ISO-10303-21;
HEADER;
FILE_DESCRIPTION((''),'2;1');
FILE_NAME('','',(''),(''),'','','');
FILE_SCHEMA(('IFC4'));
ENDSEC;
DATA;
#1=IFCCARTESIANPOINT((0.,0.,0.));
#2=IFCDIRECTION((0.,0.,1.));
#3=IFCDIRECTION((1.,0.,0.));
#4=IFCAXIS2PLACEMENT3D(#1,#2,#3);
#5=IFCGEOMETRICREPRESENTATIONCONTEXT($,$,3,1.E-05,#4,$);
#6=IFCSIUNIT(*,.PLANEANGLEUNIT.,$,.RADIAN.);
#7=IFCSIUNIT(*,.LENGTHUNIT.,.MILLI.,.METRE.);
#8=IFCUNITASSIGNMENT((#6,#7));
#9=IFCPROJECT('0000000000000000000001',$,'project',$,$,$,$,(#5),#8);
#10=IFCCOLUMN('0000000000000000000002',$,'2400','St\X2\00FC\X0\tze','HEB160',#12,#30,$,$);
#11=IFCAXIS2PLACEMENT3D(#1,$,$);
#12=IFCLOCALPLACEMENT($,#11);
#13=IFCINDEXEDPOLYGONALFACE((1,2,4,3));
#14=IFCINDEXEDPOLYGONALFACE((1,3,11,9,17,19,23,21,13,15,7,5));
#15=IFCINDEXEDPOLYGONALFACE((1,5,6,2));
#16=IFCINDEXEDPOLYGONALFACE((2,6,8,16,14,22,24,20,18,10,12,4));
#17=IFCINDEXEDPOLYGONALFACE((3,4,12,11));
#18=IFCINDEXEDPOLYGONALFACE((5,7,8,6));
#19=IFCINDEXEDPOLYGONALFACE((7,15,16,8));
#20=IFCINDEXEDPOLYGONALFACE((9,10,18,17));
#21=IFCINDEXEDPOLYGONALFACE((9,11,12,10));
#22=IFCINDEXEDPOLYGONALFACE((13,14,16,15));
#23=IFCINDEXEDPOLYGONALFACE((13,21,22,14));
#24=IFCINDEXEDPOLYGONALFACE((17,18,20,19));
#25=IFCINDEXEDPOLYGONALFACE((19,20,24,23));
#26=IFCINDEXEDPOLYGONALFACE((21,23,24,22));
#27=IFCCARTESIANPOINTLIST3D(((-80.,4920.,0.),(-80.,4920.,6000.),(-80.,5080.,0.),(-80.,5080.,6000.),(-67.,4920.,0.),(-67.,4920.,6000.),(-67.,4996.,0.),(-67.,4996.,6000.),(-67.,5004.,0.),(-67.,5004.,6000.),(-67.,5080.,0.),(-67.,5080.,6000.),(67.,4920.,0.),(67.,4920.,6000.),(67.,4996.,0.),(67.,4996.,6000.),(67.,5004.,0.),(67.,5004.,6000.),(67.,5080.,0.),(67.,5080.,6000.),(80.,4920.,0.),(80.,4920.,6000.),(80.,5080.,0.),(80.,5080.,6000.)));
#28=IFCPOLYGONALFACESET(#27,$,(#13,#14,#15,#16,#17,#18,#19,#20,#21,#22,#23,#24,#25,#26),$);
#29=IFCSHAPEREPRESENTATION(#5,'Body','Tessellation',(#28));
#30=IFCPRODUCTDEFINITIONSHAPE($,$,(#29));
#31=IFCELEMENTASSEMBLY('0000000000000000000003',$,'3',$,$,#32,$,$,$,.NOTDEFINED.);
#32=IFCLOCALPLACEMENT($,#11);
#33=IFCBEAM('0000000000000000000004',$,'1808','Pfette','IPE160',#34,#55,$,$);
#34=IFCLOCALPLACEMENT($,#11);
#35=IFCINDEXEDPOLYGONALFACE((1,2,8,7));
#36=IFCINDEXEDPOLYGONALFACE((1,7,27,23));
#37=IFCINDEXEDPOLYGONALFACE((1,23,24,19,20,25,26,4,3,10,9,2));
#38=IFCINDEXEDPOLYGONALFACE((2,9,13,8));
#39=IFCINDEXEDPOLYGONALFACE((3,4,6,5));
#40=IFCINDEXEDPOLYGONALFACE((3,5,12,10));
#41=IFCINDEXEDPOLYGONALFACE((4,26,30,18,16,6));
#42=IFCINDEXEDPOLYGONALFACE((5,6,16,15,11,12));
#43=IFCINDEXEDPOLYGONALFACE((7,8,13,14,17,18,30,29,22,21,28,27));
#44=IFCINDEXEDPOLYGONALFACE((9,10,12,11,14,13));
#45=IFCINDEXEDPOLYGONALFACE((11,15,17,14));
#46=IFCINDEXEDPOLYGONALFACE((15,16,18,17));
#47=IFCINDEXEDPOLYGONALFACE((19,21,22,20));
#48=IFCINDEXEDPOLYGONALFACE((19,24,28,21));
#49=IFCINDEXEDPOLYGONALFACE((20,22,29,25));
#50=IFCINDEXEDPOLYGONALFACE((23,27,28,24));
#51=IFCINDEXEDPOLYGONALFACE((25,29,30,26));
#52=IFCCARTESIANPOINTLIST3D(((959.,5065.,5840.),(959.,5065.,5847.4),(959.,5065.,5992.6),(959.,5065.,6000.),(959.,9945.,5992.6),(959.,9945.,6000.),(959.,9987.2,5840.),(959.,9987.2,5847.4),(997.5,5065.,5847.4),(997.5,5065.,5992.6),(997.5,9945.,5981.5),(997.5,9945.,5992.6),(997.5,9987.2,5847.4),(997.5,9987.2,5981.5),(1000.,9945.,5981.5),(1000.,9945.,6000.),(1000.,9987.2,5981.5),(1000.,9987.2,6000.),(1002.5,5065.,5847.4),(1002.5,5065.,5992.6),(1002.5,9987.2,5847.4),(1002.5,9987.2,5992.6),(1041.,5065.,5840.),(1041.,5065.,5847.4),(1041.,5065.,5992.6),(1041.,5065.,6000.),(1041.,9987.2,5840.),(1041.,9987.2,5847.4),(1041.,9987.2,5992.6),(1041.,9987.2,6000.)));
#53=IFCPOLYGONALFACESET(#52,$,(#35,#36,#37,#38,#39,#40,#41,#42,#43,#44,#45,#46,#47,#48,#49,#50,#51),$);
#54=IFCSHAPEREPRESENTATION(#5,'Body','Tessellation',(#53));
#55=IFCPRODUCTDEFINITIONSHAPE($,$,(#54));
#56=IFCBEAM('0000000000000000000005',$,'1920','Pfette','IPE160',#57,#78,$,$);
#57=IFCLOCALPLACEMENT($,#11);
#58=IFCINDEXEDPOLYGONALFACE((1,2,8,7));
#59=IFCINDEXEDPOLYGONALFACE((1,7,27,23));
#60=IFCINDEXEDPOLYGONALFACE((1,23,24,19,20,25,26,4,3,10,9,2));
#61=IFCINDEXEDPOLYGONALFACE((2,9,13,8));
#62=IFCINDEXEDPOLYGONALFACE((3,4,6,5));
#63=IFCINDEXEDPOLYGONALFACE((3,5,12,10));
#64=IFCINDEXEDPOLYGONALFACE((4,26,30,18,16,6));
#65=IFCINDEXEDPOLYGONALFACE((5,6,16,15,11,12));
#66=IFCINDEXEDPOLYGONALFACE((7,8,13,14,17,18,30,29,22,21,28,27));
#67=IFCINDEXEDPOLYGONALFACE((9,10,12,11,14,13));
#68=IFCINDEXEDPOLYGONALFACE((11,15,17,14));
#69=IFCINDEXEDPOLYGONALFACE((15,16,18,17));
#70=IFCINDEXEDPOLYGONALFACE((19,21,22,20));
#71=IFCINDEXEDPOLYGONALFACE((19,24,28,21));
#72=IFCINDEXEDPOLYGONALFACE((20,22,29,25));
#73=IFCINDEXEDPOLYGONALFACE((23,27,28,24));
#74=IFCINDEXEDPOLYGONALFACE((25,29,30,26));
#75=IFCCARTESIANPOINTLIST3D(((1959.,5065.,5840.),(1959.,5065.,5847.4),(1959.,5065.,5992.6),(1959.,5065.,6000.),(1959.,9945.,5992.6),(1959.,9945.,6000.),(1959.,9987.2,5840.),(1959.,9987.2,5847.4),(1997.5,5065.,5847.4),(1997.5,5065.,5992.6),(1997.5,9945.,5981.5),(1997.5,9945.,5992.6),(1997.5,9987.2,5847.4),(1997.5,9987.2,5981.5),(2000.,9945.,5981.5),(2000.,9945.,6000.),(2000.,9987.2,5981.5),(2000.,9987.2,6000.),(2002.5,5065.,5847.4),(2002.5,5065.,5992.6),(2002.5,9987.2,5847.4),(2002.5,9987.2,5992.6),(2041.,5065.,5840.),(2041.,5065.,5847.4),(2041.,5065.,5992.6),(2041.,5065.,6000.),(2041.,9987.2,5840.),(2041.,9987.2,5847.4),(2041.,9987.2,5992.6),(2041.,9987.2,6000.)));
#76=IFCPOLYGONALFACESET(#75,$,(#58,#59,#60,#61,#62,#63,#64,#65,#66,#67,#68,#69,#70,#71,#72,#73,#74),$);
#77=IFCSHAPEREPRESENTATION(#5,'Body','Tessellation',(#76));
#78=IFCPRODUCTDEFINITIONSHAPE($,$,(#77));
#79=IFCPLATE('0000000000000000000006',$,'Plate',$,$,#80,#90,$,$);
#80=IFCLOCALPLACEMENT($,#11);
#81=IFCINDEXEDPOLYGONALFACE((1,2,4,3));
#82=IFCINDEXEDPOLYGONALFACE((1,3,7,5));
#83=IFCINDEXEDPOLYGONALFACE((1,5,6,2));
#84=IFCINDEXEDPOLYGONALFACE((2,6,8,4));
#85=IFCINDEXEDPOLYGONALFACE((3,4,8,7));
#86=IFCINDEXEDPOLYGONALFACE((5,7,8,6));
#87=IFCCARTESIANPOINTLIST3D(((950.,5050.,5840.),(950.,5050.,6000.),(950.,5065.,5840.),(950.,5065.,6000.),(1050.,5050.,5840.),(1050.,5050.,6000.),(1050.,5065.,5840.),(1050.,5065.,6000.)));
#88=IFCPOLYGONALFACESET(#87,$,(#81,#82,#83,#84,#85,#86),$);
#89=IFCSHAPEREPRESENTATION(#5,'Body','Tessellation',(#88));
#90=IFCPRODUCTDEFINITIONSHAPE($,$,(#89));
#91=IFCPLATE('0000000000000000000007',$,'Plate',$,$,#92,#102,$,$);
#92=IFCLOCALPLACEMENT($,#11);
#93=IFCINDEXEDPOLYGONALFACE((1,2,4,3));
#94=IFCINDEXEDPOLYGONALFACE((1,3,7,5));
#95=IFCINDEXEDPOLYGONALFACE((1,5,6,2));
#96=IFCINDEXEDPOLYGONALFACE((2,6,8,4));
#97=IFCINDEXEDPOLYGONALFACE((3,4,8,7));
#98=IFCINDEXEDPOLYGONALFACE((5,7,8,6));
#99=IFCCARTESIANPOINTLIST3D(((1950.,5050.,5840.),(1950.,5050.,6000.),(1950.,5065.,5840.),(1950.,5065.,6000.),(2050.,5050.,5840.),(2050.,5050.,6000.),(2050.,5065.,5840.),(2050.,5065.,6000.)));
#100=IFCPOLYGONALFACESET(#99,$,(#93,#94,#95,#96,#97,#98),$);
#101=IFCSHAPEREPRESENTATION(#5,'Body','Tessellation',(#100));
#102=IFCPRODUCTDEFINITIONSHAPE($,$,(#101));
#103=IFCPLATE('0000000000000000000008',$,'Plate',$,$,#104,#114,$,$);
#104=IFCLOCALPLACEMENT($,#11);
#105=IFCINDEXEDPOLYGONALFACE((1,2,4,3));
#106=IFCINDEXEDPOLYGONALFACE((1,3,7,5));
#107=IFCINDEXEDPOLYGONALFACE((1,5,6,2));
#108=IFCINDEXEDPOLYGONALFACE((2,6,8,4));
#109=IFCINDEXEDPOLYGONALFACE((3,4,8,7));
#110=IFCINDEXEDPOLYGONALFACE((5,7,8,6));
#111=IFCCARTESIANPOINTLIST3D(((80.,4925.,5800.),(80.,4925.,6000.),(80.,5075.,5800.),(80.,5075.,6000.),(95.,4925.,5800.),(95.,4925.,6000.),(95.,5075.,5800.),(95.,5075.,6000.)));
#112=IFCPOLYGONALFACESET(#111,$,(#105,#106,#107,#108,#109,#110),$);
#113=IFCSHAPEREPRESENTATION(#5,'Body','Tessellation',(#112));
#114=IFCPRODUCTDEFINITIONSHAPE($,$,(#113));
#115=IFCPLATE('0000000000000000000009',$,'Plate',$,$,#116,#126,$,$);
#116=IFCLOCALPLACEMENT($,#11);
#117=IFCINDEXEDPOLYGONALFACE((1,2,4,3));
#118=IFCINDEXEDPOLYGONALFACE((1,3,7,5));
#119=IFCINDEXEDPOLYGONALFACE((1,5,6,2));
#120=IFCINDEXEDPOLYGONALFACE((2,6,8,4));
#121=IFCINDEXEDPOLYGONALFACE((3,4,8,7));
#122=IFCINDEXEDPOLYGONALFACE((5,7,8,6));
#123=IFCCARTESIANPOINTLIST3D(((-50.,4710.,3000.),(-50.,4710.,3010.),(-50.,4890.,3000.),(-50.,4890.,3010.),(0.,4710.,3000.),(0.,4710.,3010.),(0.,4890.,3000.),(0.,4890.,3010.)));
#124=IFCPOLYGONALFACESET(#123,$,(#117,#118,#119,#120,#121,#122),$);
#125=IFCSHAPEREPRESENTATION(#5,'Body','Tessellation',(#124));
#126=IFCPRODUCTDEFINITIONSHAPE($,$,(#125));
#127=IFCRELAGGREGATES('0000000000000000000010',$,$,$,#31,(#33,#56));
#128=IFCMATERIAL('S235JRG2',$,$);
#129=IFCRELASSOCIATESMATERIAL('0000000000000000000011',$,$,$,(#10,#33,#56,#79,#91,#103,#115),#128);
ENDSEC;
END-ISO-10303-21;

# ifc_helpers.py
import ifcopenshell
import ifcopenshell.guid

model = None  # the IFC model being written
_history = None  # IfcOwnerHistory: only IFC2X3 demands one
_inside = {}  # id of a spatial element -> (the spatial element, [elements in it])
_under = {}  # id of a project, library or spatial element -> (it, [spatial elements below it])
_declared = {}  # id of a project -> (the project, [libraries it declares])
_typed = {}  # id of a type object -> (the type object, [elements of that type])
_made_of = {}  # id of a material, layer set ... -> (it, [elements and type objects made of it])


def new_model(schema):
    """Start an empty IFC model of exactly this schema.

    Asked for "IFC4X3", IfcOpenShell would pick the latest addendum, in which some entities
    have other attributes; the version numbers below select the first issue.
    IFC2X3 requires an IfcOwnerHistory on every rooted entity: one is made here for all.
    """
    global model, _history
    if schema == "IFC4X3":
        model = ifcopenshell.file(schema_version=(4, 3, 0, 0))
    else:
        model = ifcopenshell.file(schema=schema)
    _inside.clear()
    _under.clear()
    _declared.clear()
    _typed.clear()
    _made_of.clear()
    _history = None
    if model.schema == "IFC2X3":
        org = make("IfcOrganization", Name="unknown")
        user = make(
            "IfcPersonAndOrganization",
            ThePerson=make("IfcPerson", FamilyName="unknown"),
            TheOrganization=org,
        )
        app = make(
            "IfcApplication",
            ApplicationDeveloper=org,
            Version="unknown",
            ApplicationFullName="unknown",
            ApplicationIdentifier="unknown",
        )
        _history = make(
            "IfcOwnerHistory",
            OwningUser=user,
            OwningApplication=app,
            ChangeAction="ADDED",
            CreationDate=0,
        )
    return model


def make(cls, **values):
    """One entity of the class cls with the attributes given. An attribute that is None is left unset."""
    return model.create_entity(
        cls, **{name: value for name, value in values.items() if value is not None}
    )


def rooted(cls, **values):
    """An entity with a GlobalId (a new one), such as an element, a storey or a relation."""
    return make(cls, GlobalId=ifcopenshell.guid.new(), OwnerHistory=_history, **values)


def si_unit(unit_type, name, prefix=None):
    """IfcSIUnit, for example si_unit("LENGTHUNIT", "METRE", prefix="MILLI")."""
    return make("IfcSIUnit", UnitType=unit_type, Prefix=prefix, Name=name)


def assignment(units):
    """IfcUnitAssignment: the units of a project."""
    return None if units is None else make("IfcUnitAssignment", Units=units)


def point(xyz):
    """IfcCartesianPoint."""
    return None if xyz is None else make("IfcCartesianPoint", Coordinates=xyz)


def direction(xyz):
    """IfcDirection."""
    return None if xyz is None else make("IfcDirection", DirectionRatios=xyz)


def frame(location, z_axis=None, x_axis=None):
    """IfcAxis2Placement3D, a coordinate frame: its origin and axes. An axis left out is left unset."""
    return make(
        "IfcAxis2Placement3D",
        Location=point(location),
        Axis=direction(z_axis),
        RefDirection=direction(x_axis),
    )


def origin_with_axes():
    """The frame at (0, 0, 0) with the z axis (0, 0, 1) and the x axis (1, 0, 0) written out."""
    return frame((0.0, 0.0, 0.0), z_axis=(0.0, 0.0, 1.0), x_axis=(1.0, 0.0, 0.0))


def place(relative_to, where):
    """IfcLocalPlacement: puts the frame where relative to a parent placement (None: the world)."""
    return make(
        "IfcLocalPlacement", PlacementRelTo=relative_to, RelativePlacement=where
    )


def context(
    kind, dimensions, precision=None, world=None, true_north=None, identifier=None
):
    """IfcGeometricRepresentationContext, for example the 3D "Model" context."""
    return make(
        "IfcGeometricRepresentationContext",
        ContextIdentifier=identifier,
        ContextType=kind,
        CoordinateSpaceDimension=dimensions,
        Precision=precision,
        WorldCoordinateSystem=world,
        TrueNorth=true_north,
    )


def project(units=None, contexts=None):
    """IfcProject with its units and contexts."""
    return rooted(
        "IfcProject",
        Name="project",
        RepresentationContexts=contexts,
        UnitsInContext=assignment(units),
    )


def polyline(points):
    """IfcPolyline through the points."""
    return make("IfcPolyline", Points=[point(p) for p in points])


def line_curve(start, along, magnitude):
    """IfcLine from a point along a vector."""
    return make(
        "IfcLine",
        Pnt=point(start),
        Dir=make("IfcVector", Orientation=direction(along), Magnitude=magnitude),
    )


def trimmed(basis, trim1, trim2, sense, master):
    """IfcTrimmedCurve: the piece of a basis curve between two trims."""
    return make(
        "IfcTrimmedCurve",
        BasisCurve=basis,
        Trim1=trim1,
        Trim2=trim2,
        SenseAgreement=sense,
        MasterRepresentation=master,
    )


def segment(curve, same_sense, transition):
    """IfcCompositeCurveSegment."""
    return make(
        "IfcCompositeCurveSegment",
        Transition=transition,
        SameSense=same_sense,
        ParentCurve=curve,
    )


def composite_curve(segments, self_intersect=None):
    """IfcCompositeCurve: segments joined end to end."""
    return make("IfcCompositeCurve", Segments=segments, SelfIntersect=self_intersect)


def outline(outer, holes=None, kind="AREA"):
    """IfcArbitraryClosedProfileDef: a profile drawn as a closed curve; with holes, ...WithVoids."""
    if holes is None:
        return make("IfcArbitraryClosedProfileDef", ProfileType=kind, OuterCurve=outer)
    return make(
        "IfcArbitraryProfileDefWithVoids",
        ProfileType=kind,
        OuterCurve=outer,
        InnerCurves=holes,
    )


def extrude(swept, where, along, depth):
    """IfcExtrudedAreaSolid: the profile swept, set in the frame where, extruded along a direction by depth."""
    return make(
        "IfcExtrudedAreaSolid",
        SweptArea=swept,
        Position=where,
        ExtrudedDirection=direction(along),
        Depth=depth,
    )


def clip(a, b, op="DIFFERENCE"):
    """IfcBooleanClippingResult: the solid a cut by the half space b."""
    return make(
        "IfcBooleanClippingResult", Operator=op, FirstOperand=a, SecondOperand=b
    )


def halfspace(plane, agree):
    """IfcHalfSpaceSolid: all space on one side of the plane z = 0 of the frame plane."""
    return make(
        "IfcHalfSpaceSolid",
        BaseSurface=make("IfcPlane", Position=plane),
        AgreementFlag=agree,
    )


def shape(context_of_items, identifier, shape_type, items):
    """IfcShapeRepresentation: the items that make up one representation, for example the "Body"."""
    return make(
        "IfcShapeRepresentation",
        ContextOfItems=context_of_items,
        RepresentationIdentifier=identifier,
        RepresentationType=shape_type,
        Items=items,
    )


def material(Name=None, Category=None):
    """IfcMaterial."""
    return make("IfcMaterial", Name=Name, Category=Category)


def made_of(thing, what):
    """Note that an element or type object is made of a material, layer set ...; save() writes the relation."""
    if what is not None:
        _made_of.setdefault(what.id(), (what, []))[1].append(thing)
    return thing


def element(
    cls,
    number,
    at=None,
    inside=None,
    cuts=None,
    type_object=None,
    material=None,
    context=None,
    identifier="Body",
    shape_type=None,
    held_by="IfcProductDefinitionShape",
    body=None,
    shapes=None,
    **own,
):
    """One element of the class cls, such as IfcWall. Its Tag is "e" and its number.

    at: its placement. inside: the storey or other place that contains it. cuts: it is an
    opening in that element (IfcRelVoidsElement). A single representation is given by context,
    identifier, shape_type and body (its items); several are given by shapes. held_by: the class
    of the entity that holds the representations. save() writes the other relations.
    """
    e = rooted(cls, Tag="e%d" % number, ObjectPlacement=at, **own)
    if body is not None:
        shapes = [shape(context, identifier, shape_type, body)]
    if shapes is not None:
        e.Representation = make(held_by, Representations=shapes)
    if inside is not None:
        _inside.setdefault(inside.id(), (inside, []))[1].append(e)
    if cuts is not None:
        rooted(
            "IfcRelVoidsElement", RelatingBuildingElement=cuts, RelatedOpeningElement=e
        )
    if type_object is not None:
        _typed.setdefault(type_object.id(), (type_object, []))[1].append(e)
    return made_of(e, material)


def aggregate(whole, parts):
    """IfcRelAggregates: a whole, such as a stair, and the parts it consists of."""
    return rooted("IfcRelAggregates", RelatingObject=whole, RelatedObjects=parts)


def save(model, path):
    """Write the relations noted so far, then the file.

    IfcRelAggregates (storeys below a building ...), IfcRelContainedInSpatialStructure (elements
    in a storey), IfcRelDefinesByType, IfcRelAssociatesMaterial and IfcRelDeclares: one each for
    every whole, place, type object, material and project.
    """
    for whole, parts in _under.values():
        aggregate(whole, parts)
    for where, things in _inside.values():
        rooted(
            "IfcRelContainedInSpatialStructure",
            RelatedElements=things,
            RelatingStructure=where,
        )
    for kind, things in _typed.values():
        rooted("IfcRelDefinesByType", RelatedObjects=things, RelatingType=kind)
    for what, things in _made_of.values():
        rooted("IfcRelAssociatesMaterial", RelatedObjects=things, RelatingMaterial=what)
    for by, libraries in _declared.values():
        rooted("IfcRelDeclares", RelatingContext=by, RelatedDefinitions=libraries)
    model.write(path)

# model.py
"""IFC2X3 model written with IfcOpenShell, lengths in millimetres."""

from ifc_helpers import new_model, si_unit, point, frame, origin_with_axes, place, context, project, polyline, line_curve, trimmed, segment, composite_curve, outline, extrude, clip, halfspace, material, element, aggregate, save


model = new_model("IFC2X3")

# Units and contexts
context_of_model = context(None, 3, precision=1e-05, world=origin_with_axes())
ifc_project = project(units=[si_unit("PLANEANGLEUNIT", "RADIAN"), si_unit("LENGTHUNIT", "METRE", prefix="MILLI")], contexts=[context_of_model])

# Column
ifc_material = material(Name="S235JRG2")
placement_1 = place(None, frame((0.0, 5000.0, 6000.0), z_axis=(-1.0, 0.0, 0.0), x_axis=(0.0, 0.0, -1.0)))
column_placement = place(placement_1, origin_with_axes())
element("IfcColumn", 1, at=column_placement, material=ifc_material, Name="2400", Description="Stütze", ObjectType="HEB160", context=context_of_model, shape_type="Clipping", body=[
    clip(extrude(outline(polyline([(80.0, -80.0), (80.0, -67.0), (4.0, -67.0), (4.0, 67.0), (80.0, 67.0), (80.0, 80.0), (-80.0, 80.0), (-80.0, 67.0), (-4.0, 67.0), (-4.0, -67.0), (-80.0, -67.0), (-80.0, -80.0), (80.0, -80.0), (80.0, -80.0)])), frame((0.0, 0.0, 0.0), z_axis=(1.0, 0.0, 0.0), x_axis=(0.0, 1.0, 0.0)), (0.0, 0.0, 1.0), 6000.0), halfspace(frame((6000.0, 0.0, 0.0), z_axis=(1.0, 0.0, 0.0), x_axis=(0.0, 0.0, 1.0)), False)),
])

# Element assembly, beams, openings
assembly_1_placement = place(None, frame((1000.0, 5002.5, 6000.0), z_axis=(0.0, 0.0, 1.0), x_axis=(0.0, 1.0, 0.0)))
assembly_1 = element("IfcElementAssembly", 2, at=assembly_1_placement, Name="3", PredefinedType="NOTDEFINED")
placement_2 = place(None, frame((1000.0, 5002.5, 5920.0), z_axis=(0.0, 0.0, 1.0), x_axis=(0.0, 1.0, 0.0)))
beam_1_placement = place(placement_2, origin_with_axes())
beam_1 = element("IfcBeam", 3, at=beam_1_placement, material=ifc_material, Name="1808", Description="Pfette", ObjectType="IPE160", context=context_of_model, shape_type="Clipping", body=[
    clip(clip(extrude(outline(polyline([(41.0, -80.0), (41.0, -72.6), (2.5, -72.6), (2.5, 72.6), (41.0, 72.6), (41.0, 80.0), (-41.0, 80.0), (-41.0, 72.6), (-2.5, 72.6), (-2.5, -72.6), (-41.0, -72.6), (-41.0, -80.0), (41.0, -80.0), (41.0, -80.0)])), frame((0.0, 0.0, 0.0), z_axis=(1.0, 0.0, 0.0), x_axis=(0.0, 1.0, 0.0)), (0.0, 0.0, 1.0), 4997.5), halfspace(frame((62.5, 0.0, 80.0), z_axis=(-1.0, 0.0, 0.0), x_axis=(0.0, 0.0, -1.0)), False)), halfspace(frame((4984.7, 0.0, 80.0), z_axis=(1.0, 0.0, 0.0), x_axis=(0.0, 0.0, 1.0)), False)),
])
opening_1_placement = place(beam_1_placement, frame((4942.5, 0.0, 61.5), z_axis=(0.0, 1.0, 0.0), x_axis=(-1.0, 0.0, 0.0)))
element("IfcOpeningElement", 4, at=opening_1_placement, cuts=beam_1, ObjectType="Recess", context=context_of_model, shape_type="SweptSolid", body=[
    extrude(outline(composite_curve([segment(trimmed(line_curve((0.0, 0.0), (0.0, 1.0, 0.0), 18.501), [point((0.0, 0.0))], [point((0.0, 18.5))], True, "CARTESIAN"), True, "CONTINUOUS"), segment(trimmed(line_curve((0.0, 18.5), (-1.0, 0.0, 0.0), 42.201), [point((0.0, 18.5))], [point((-42.2, 18.5))], True, "CARTESIAN"), True, "CONTINUOUS"), segment(trimmed(line_curve((-42.2, 18.5), (0.0, -1.0, 0.0), 18.501), [point((-42.2, 18.5))], [point((-42.2, 0.0))], True, "CARTESIAN"), True, "CONTINUOUS"), segment(trimmed(line_curve((-42.2, 0.0), (1.0, 0.0, 0.0), 42.201), [point((-42.2, 0.0))], [point((0.0, 0.0))], True, "CARTESIAN"), True, "CONTINUOUS")], self_intersect=False)), origin_with_axes(), (0.0, 0.0, 1.0), 3000.0),
])
placement_3 = place(None, frame((2000.0, 5002.5, 5920.0), z_axis=(0.0, 0.0, 1.0), x_axis=(0.0, 1.0, 0.0)))
beam_2_placement = place(placement_3, origin_with_axes())
beam_2 = element("IfcBeam", 5, at=beam_2_placement, material=ifc_material, Name="1920", Description="Pfette", ObjectType="IPE160", context=context_of_model, shape_type="Clipping", body=[
    clip(clip(extrude(outline(polyline([(41.0, -80.0), (41.0, -72.6), (2.5, -72.6), (2.5, 72.6), (41.0, 72.6), (41.0, 80.0), (-41.0, 80.0), (-41.0, 72.6), (-2.5, 72.6), (-2.5, -72.6), (-41.0, -72.6), (-41.0, -80.0), (41.0, -80.0), (41.0, -80.0)])), frame((0.0, 0.0, 0.0), z_axis=(1.0, 0.0, 0.0), x_axis=(0.0, 1.0, 0.0)), (0.0, 0.0, 1.0), 4997.5), halfspace(frame((62.5, 0.0, 80.0), z_axis=(-1.0, 0.0, 0.0), x_axis=(0.0, 0.0, -1.0)), False)), halfspace(frame((4984.7, 0.0, 80.0), z_axis=(1.0, 0.0, 0.0), x_axis=(0.0, 0.0, 1.0)), False)),
])
opening_2_placement = place(beam_2_placement, frame((4942.5, 0.0, 61.5), z_axis=(0.0, 1.0, 0.0), x_axis=(-1.0, 0.0, 0.0)))
element("IfcOpeningElement", 6, at=opening_2_placement, cuts=beam_2, ObjectType="Recess", context=context_of_model, shape_type="SweptSolid", body=[
    extrude(outline(composite_curve([segment(trimmed(line_curve((0.0, 0.0), (0.0, 1.0, 0.0), 18.501), [point((0.0, 0.0))], [point((0.0, 18.5))], True, "CARTESIAN"), True, "CONTINUOUS"), segment(trimmed(line_curve((0.0, 18.5), (-1.0, 0.0, 0.0), 42.201), [point((0.0, 18.5))], [point((-42.2, 18.5))], True, "CARTESIAN"), True, "CONTINUOUS"), segment(trimmed(line_curve((-42.2, 18.5), (0.0, -1.0, 0.0), 18.501), [point((-42.2, 18.5))], [point((-42.2, 0.0))], True, "CARTESIAN"), True, "CONTINUOUS"), segment(trimmed(line_curve((-42.2, 0.0), (1.0, 0.0, 0.0), 42.201), [point((-42.2, 0.0))], [point((0.0, 0.0))], True, "CARTESIAN"), True, "CONTINUOUS")], self_intersect=False)), origin_with_axes(), (0.0, 0.0, 1.0), 3000.0),
])
aggregate(assembly_1, [beam_1, beam_2])

# Plates
placement_4 = place(None, origin_with_axes())
plate_1_placement = place(placement_4, frame((1050.0, 5065.0, 5840.0), z_axis=(-1.0, 0.0, 0.0), x_axis=(0.0, -1.0, 0.0)))
element("IfcPlate", 7, at=plate_1_placement, material=ifc_material, Name="Plate", context=context_of_model, shape_type="SweptSolid", body=[
    extrude(outline(polyline([(0.0, 0.0), (160.0, 0.0), (160.0, 100.0), (0.0, 100.0), (0.0, 0.0)])), frame((0.0, 0.0, 0.0), z_axis=(1.0, 0.0, 0.0), x_axis=(0.0, 1.0, 0.0)), (0.0, 0.0, 1.0), 15.0),
])
placement_5 = place(None, origin_with_axes())
plate_2_placement = place(placement_5, frame((2050.0, 5065.0, 5840.0), z_axis=(-1.0, 0.0, 0.0), x_axis=(0.0, -1.0, 0.0)))
element("IfcPlate", 8, at=plate_2_placement, material=ifc_material, Name="Plate", context=context_of_model, shape_type="SweptSolid", body=[
    extrude(outline(polyline([(0.0, 0.0), (160.0, 0.0), (160.0, 100.0), (0.0, 100.0), (0.0, 0.0)])), frame((0.0, 0.0, 0.0), z_axis=(1.0, 0.0, 0.0), x_axis=(0.0, 1.0, 0.0)), (0.0, 0.0, 1.0), 15.0),
])
placement_6 = place(None, origin_with_axes())
plate_3_placement = place(placement_6, frame((95.0, 4925.0, 5800.0), z_axis=(0.0, 1.0, 0.0), x_axis=(-1.0, 0.0, 0.0)))
element("IfcPlate", 9, at=plate_3_placement, material=ifc_material, Name="Plate", context=context_of_model, shape_type="SweptSolid", body=[
    extrude(outline(polyline([(0.0, 0.0), (200.0, 0.0), (200.0, 150.0), (0.0, 150.0), (0.0, 0.0)])), frame((0.0, 0.0, 0.0), z_axis=(1.0, 0.0, 0.0), x_axis=(0.0, 1.0, 0.0)), (0.0, 0.0, 1.0), 15.0),
])
placement_7 = place(None, origin_with_axes())
plate_4_placement = place(placement_7, frame((0.0, 4890.0, 3010.0), z_axis=(-1.0, 0.0, 0.0), x_axis=(0.0, 0.0, -1.0)))
element("IfcPlate", 10, at=plate_4_placement, material=ifc_material, Name="Plate", context=context_of_model, shape_type="SweptSolid", body=[
    extrude(outline(polyline([(0.0, 0.0), (180.0, 0.0), (180.0, 50.0), (0.0, 50.0), (0.0, 0.0)])), frame((0.0, 0.0, 0.0), z_axis=(1.0, 0.0, 0.0), x_axis=(0.0, 1.0, 0.0)), (0.0, 0.0, 1.0), 10.0),
])

save(model, "model.ifc")
